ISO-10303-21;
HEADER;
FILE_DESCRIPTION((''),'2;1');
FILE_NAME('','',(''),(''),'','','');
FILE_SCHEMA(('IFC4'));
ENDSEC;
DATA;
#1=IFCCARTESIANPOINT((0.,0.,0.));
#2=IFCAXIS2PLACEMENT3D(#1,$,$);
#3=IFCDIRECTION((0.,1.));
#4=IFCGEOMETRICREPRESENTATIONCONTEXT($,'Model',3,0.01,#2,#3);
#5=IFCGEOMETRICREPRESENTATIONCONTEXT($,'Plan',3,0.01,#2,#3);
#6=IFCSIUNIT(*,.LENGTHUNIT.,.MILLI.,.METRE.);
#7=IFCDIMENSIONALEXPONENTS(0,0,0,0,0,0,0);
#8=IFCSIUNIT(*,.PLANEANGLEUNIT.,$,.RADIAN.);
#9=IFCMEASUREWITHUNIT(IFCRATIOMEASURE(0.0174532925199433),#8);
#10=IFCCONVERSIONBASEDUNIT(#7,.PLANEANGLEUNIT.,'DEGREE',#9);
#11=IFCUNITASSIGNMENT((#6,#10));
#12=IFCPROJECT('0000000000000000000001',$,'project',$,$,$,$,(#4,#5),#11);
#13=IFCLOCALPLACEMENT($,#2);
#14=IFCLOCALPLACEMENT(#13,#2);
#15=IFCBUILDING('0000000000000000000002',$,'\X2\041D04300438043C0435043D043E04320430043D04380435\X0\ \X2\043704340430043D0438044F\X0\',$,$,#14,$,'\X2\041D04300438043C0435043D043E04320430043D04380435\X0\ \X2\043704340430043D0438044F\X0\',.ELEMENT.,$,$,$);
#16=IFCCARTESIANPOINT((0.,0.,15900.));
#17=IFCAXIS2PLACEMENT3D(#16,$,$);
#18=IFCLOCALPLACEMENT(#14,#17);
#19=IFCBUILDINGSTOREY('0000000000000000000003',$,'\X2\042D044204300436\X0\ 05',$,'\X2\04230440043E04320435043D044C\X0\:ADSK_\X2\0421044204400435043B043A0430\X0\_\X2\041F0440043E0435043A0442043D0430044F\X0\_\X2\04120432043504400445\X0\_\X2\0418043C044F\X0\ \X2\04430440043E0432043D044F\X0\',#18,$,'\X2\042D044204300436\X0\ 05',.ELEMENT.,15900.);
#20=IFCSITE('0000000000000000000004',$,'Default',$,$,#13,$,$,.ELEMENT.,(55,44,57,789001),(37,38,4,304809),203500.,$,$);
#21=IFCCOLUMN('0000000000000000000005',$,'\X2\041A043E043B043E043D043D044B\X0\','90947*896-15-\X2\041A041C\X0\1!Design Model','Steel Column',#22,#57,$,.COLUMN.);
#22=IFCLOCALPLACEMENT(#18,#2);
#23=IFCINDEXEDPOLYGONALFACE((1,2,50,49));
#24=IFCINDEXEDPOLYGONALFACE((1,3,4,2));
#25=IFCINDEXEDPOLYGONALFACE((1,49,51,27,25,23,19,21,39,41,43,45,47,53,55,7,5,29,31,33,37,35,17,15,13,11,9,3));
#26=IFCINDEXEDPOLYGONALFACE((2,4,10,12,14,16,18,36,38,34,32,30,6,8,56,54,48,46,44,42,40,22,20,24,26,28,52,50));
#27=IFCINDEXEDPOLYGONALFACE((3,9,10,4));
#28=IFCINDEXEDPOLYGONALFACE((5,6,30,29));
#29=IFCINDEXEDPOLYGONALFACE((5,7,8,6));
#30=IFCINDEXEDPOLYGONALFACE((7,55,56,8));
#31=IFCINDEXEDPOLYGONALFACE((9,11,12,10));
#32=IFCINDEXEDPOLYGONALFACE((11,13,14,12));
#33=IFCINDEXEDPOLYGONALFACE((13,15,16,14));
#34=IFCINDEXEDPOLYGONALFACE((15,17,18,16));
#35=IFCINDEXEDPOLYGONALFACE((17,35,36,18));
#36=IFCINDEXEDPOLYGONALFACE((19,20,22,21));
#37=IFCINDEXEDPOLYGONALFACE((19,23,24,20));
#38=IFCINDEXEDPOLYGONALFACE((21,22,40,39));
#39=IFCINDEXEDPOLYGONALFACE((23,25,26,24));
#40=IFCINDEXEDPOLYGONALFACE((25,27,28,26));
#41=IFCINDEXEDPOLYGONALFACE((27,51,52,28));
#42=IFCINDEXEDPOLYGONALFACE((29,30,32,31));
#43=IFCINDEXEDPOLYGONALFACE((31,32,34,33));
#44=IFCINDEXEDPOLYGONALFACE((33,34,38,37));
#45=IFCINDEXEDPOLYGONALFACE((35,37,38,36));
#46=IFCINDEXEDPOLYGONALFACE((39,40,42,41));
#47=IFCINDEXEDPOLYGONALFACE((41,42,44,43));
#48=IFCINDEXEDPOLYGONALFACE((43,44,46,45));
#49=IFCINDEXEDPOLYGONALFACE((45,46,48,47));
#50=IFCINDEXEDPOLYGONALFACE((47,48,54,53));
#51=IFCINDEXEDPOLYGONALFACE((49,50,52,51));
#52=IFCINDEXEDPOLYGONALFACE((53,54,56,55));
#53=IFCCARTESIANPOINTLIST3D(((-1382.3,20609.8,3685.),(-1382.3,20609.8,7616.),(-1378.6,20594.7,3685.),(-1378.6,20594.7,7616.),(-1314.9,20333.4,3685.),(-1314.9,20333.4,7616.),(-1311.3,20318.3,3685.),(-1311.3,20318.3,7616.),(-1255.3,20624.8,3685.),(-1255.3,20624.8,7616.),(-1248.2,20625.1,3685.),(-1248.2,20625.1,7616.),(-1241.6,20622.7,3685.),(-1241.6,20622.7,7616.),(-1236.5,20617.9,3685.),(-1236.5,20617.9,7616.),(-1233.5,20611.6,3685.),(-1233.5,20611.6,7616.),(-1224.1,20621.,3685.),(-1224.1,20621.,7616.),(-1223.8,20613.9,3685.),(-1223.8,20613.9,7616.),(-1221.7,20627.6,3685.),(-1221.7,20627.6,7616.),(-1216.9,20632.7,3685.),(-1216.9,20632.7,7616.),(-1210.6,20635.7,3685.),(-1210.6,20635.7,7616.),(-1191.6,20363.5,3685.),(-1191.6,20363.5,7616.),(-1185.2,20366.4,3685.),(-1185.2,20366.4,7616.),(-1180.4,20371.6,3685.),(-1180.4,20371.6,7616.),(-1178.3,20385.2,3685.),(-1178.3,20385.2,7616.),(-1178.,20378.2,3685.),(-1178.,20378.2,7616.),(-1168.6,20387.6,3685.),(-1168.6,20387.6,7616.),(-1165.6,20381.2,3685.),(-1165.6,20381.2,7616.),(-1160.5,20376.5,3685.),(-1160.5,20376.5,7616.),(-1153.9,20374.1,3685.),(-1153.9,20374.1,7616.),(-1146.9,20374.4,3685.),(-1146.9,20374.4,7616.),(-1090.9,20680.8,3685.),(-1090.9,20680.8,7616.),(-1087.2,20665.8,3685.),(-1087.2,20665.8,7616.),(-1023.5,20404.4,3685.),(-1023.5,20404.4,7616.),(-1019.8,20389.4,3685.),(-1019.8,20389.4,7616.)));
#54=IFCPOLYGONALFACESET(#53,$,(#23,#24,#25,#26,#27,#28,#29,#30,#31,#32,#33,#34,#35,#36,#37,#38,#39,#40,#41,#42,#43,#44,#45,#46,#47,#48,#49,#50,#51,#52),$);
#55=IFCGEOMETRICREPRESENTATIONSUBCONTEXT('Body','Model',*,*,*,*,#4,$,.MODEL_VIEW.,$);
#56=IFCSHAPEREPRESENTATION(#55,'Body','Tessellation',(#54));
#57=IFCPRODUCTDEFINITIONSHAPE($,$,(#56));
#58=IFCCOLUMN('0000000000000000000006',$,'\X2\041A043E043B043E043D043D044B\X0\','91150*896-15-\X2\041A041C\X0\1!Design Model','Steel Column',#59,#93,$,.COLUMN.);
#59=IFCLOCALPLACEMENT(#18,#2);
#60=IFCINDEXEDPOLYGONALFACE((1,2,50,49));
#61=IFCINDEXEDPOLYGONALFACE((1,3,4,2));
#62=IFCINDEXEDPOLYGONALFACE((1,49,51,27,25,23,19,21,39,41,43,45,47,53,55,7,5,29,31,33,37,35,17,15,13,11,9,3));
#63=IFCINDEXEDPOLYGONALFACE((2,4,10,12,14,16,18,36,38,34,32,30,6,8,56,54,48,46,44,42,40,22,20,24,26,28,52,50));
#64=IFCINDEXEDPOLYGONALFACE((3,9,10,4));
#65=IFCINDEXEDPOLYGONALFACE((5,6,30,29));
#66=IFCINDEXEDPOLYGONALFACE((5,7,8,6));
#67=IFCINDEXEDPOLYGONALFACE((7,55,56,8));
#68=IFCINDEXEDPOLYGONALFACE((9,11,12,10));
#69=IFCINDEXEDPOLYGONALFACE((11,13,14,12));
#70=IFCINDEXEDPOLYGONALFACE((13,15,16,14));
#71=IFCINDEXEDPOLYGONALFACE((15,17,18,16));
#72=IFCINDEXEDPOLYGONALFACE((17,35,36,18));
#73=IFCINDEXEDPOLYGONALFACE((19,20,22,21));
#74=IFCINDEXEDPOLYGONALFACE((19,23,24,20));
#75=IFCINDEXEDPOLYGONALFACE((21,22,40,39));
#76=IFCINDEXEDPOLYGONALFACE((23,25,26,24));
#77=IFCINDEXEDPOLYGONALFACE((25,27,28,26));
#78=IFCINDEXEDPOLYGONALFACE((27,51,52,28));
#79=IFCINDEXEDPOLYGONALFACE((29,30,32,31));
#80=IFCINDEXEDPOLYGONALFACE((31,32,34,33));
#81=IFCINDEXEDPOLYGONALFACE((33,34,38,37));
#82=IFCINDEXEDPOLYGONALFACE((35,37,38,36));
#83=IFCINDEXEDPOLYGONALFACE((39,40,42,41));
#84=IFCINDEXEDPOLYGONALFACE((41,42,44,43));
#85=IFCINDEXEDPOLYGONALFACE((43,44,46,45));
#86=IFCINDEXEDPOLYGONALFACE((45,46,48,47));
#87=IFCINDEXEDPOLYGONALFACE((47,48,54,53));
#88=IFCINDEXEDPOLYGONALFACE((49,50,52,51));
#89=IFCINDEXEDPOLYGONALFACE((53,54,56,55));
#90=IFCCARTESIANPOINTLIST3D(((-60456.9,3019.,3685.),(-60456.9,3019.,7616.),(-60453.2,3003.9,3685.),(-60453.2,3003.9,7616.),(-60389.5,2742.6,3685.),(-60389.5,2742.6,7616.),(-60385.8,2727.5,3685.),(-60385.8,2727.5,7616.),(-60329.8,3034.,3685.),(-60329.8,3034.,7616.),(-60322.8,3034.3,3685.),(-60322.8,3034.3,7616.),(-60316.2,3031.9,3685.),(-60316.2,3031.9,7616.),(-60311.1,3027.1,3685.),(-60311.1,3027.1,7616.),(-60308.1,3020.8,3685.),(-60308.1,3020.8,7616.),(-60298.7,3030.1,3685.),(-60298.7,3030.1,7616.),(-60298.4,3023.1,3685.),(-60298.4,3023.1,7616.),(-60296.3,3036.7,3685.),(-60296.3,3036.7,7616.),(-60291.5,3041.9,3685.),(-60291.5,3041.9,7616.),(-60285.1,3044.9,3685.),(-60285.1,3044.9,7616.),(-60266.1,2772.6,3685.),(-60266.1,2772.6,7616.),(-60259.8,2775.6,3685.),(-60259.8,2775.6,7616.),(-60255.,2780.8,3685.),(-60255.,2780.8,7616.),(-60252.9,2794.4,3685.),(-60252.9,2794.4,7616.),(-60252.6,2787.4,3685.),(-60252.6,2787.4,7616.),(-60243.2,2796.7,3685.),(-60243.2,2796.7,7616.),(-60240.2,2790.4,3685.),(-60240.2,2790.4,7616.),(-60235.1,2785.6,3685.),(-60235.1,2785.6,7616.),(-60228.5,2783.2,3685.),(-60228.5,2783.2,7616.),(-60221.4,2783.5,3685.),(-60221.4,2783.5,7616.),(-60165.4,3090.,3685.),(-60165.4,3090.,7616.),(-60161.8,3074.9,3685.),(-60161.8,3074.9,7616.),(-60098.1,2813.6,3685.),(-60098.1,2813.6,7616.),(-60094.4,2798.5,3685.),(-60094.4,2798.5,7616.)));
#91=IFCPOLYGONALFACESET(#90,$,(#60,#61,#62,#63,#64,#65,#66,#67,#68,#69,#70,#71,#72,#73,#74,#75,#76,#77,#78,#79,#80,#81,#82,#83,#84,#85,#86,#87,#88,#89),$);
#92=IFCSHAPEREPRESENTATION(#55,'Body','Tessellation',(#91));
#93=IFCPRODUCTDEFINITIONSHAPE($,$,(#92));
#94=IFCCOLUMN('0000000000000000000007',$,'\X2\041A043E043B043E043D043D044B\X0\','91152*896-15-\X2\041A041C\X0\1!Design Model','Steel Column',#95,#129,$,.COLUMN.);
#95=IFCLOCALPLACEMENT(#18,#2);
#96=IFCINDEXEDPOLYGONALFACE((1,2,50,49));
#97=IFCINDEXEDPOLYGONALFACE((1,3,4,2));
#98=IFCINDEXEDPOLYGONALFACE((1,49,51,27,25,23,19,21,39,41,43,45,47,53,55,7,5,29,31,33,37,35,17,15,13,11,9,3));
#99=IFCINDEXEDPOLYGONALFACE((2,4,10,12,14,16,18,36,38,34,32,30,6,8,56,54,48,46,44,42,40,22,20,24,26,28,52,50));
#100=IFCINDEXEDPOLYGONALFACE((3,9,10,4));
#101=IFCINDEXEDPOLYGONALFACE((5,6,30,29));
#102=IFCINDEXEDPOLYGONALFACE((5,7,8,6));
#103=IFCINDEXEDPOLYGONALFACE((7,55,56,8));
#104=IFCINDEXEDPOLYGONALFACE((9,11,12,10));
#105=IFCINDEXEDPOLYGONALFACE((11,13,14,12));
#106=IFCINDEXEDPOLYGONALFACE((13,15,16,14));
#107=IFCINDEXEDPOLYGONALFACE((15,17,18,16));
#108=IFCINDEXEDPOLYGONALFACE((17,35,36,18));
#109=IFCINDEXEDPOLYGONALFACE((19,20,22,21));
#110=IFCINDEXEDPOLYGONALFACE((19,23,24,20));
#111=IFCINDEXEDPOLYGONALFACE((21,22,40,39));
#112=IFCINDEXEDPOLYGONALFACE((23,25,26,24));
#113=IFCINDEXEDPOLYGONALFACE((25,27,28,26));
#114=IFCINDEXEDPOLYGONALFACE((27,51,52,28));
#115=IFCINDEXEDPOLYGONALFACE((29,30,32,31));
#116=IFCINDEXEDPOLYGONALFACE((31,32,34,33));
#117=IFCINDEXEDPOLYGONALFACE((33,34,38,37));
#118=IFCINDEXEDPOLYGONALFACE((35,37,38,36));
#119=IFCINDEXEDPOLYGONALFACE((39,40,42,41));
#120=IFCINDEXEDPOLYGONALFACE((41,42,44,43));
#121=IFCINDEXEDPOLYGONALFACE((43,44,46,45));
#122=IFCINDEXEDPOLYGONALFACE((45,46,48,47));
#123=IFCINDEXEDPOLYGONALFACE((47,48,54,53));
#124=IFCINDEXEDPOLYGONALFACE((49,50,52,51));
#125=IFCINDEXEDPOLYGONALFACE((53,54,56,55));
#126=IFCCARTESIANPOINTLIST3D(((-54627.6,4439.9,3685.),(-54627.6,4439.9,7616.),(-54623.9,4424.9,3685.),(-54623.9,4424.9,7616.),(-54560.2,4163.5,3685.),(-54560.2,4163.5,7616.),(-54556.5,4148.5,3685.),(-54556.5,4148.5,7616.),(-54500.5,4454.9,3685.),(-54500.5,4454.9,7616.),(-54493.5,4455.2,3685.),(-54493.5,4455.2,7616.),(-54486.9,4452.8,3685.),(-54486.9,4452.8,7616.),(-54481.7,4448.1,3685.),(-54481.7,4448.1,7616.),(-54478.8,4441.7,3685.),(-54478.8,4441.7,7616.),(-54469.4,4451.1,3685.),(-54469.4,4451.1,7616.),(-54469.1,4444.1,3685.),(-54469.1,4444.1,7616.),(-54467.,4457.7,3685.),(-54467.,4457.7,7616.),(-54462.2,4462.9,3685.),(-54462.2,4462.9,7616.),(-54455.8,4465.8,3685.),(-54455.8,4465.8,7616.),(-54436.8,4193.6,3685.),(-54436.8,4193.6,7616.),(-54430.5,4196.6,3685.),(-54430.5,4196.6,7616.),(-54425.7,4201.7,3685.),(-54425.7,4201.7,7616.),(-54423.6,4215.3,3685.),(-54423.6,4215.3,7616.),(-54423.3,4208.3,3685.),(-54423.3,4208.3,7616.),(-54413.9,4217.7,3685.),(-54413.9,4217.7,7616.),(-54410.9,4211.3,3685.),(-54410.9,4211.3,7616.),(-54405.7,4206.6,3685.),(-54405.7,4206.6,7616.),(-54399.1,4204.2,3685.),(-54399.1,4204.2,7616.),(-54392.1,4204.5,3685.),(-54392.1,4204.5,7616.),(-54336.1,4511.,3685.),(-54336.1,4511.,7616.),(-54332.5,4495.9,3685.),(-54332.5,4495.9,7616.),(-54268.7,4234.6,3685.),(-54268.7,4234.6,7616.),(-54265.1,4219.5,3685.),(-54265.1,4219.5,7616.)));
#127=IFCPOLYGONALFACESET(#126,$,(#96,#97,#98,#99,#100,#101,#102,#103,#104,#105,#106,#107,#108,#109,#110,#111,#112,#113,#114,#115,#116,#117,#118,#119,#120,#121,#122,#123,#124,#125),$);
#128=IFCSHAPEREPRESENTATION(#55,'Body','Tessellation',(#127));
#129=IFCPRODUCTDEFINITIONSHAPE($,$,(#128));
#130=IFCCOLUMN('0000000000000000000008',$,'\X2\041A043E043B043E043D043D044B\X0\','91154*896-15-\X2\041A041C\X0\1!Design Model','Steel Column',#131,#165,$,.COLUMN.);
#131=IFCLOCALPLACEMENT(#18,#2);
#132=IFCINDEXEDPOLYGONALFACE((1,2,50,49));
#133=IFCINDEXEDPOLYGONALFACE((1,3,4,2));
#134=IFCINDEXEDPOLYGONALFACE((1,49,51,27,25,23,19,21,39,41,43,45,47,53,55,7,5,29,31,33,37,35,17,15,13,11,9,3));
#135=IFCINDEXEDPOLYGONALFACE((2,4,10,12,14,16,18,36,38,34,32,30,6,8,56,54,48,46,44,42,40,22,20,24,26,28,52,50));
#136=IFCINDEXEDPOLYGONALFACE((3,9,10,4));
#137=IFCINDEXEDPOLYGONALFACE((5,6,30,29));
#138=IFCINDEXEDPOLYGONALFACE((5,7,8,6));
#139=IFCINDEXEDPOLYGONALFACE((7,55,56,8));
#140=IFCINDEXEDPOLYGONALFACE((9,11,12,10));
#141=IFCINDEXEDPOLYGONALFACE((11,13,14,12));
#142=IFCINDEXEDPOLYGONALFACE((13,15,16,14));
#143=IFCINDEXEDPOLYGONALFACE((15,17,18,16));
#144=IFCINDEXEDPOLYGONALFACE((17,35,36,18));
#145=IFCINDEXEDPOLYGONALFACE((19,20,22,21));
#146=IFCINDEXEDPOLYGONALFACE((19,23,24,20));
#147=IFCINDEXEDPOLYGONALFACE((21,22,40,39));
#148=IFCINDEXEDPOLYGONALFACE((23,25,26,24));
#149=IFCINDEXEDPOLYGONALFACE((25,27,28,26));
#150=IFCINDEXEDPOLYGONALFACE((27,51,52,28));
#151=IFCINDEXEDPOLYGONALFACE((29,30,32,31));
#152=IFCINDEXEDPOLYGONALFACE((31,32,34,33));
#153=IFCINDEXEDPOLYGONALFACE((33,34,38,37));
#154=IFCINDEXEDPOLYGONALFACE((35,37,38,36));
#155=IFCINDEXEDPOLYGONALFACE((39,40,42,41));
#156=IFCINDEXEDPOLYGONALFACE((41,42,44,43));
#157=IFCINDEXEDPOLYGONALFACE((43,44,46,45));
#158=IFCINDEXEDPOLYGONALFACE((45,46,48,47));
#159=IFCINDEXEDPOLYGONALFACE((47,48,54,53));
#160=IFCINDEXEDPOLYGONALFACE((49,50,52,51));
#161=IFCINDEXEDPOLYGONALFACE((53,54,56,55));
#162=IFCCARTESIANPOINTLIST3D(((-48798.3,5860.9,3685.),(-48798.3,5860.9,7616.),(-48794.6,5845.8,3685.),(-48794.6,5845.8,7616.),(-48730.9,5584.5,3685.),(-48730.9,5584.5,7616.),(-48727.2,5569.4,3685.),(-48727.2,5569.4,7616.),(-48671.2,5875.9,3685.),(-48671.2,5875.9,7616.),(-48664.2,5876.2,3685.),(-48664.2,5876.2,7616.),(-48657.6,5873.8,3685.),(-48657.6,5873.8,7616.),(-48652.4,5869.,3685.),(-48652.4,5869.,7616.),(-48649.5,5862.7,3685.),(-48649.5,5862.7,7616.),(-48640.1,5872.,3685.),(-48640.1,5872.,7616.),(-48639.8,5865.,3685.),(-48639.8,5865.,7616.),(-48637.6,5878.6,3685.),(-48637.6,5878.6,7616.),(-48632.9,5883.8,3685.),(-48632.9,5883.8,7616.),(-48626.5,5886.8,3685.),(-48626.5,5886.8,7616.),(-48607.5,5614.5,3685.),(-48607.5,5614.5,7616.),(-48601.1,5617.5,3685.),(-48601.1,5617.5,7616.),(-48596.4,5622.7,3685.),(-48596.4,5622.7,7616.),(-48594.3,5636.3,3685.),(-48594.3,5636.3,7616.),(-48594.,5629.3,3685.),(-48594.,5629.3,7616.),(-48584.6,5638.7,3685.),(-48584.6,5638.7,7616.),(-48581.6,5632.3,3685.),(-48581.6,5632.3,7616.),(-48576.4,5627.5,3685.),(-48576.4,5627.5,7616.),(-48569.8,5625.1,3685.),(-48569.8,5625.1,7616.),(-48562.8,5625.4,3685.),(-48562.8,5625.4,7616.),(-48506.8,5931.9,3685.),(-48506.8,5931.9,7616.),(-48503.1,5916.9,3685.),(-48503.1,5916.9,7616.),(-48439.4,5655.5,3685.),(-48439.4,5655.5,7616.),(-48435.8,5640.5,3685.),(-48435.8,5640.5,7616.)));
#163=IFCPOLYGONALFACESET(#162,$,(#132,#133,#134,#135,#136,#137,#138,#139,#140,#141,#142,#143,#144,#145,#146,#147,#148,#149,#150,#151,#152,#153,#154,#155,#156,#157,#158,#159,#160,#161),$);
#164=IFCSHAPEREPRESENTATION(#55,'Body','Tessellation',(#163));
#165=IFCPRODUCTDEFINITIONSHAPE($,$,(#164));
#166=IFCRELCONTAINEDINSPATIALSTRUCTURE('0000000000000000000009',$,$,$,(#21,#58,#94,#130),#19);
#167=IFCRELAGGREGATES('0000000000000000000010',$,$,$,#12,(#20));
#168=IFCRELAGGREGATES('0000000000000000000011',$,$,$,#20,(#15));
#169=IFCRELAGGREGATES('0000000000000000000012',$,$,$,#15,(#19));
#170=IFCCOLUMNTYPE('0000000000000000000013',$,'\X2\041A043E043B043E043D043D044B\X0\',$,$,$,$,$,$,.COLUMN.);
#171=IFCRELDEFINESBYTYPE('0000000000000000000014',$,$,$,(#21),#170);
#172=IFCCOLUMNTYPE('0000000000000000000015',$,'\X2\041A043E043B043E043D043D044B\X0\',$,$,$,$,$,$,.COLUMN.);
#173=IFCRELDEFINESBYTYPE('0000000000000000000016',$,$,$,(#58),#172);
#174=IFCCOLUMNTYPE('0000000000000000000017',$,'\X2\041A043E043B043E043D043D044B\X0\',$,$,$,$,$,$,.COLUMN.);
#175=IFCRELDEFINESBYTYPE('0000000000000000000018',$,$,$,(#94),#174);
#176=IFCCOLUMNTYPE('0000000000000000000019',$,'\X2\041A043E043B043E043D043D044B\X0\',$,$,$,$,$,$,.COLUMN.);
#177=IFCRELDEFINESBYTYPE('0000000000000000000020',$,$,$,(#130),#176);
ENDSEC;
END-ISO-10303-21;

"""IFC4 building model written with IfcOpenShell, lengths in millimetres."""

from ifc_helpers import new_model, entity, si_unit, converted_unit, direction, frame, origin, place, context, subcontext, project, spatial, indexed_curve, outline, extrude, type_object, element, save


model = new_model("IFC4")

# Units and contexts
model_context = context("Model", 3, precision=0.01, world=origin(), true_north=direction((0.0, 1.0)))
plan_context = context("Plan", 3, precision=0.01, world=origin(), true_north=direction((0.0, 1.0)))
body_context = subcontext(model_context, "Body", "Model", "MODEL_VIEW")
ifc_project = project(units=[si_unit("LENGTHUNIT", "METRE", prefix="MILLI"), converted_unit("PLANEANGLEUNIT", "DEGREE", entity("IfcRatioMeasure", 0.0174532925199433), si_unit("PLANEANGLEUNIT", "RADIAN"), dimensions=[0, 0, 0, 0, 0, 0, 0])], contexts=[model_context, plan_context])

# Site, building, storey
site_placement = place(None, origin())
site = spatial("IfcSite", under=ifc_project, at=site_placement, Name="Default", CompositionType="ELEMENT", RefLatitude=(55, 44, 57, 789001), RefLongitude=(37, 38, 4, 304809), RefElevation=203500.0)
building_placement = place(site_placement, origin())
building = spatial("IfcBuilding", under=site, at=building_placement, Name="Наименование здания", LongName="Наименование здания", CompositionType="ELEMENT")
storey_placement = place(building_placement, frame((0.0, 0.0, 15900.0)))
storey = spatial("IfcBuildingStorey", under=building, at=storey_placement, Name="Этаж 05", ObjectType="Уровень:ADSK_Стрелка_Проектная_Вверх_Имя уровня", LongName="Этаж 05", CompositionType="ELEMENT", Elevation=15900.0)

# Columns
column_type_1 = type_object("IfcColumnType", Name="Колонны", PredefinedType="COLUMN")
placement = place(storey_placement, origin())
element("IfcColumn", 1, at=placement, inside=storey, type_object=column_type_1, Name="Колонны", Description="90947*896-15-КМ1!Design Model", ObjectType="Steel Column", PredefinedType="COLUMN", context=body_context, shape_type="SweptSolid", body=[
    extrude(outline(indexed_curve([(-150.0, -150.0), (-134.5, -150.0), (-134.5, -23.0), (-133.1, -16.1), (-129.2, -10.3), (-123.4, -6.4), (-116.5, -5.0), (116.5, -5.0), (123.4, -6.4), (129.2, -10.3), (133.1, -16.1), (134.5, -23.0), (134.5, -150.0), (150.0, -150.0), (150.0, 150.0), (134.5, 150.0), (134.5, 23.0), (133.1, 16.1), (129.2, 10.3), (123.4, 6.4), (116.5, 5.0), (-116.5, 5.0), (-123.4, 6.4), (-129.2, 10.3), (-133.1, 16.1), (-134.5, 23.0), (-134.5, 150.0), (-150.0, 150.0), (-150.0, -150.0)], self_intersect=False)), frame((-1201.1, 20499.6, 3685.0), z_axis=(0.0, 0.0, 1.0), x_axis=(-0.236826, 0.971552, 0.0)), (0.0, 0.0, 1.0), 3931.0),
])
column_type_2 = type_object("IfcColumnType", Name="Колонны", PredefinedType="COLUMN")
element("IfcColumn", 2, at=placement, inside=storey, type_object=column_type_2, Name="Колонны", Description="91150*896-15-КМ1!Design Model", ObjectType="Steel Column", PredefinedType="COLUMN", context=body_context, shape_type="SweptSolid", body=[
    extrude(outline(indexed_curve([(-150.0, -150.0), (-134.5, -150.0), (-134.5, -23.0), (-133.1, -16.1), (-129.2, -10.3), (-123.4, -6.4), (-116.5, -5.0), (116.5, -5.0), (123.4, -6.4), (129.2, -10.3), (133.1, -16.1), (134.5, -23.0), (134.5, -150.0), (150.0, -150.0), (150.0, 150.0), (134.5, 150.0), (134.5, 23.0), (133.1, 16.1), (129.2, 10.3), (123.4, 6.4), (116.5, 5.0), (-116.5, 5.0), (-123.4, 6.4), (-129.2, 10.3), (-133.1, 16.1), (-134.5, 23.0), (-134.5, 150.0), (-150.0, 150.0), (-150.0, -150.0)], self_intersect=False)), frame((-60275.6, 2908.8, 3685.0), z_axis=(0.0, 0.0, 1.0), x_axis=(-0.236826, 0.971552, 0.0)), (0.0, 0.0, 1.0), 3931.0),
])
column_type_3 = type_object("IfcColumnType", Name="Колонны", PredefinedType="COLUMN")
element("IfcColumn", 3, at=placement, inside=storey, type_object=column_type_3, Name="Колонны", Description="91152*896-15-КМ1!Design Model", ObjectType="Steel Column", PredefinedType="COLUMN", context=body_context, shape_type="SweptSolid", body=[
    extrude(outline(indexed_curve([(-150.0, -150.0), (-134.5, -150.0), (-134.5, -23.0), (-133.1, -16.1), (-129.2, -10.3), (-123.4, -6.4), (-116.5, -5.0), (116.5, -5.0), (123.4, -6.4), (129.2, -10.3), (133.1, -16.1), (134.5, -23.0), (134.5, -150.0), (150.0, -150.0), (150.0, 150.0), (134.5, 150.0), (134.5, 23.0), (133.1, 16.1), (129.2, 10.3), (123.4, 6.4), (116.5, 5.0), (-116.5, 5.0), (-123.4, 6.4), (-129.2, 10.3), (-133.1, 16.1), (-134.5, 23.0), (-134.5, 150.0), (-150.0, 150.0), (-150.0, -150.0)], self_intersect=False)), frame((-54446.3, 4329.7, 3685.0), z_axis=(0.0, 0.0, 1.0), x_axis=(-0.236826, 0.971552, 0.0)), (0.0, 0.0, 1.0), 3931.0),
])
column_type_4 = type_object("IfcColumnType", Name="Колонны", PredefinedType="COLUMN")
element("IfcColumn", 4, at=placement, inside=storey, type_object=column_type_4, Name="Колонны", Description="91154*896-15-КМ1!Design Model", ObjectType="Steel Column", PredefinedType="COLUMN", context=body_context, shape_type="SweptSolid", body=[
    extrude(outline(indexed_curve([(-150.0, -150.0), (-134.5, -150.0), (-134.5, -23.0), (-133.1, -16.1), (-129.2, -10.3), (-123.4, -6.4), (-116.5, -5.0), (116.5, -5.0), (123.4, -6.4), (129.2, -10.3), (133.1, -16.1), (134.5, -23.0), (134.5, -150.0), (150.0, -150.0), (150.0, 150.0), (134.5, 150.0), (134.5, 23.0), (133.1, 16.1), (129.2, 10.3), (123.4, 6.4), (116.5, 5.0), (-116.5, 5.0), (-123.4, 6.4), (-129.2, 10.3), (-133.1, 16.1), (-134.5, 23.0), (-134.5, 150.0), (-150.0, 150.0), (-150.0, -150.0)], self_intersect=False)), frame((-48617.0, 5750.7, 3685.0), z_axis=(0.0, 0.0, 1.0), x_axis=(-0.236826, 0.971552, 0.0)), (0.0, 0.0, 1.0), 3931.0),
])

save(model, "model.ifc")
